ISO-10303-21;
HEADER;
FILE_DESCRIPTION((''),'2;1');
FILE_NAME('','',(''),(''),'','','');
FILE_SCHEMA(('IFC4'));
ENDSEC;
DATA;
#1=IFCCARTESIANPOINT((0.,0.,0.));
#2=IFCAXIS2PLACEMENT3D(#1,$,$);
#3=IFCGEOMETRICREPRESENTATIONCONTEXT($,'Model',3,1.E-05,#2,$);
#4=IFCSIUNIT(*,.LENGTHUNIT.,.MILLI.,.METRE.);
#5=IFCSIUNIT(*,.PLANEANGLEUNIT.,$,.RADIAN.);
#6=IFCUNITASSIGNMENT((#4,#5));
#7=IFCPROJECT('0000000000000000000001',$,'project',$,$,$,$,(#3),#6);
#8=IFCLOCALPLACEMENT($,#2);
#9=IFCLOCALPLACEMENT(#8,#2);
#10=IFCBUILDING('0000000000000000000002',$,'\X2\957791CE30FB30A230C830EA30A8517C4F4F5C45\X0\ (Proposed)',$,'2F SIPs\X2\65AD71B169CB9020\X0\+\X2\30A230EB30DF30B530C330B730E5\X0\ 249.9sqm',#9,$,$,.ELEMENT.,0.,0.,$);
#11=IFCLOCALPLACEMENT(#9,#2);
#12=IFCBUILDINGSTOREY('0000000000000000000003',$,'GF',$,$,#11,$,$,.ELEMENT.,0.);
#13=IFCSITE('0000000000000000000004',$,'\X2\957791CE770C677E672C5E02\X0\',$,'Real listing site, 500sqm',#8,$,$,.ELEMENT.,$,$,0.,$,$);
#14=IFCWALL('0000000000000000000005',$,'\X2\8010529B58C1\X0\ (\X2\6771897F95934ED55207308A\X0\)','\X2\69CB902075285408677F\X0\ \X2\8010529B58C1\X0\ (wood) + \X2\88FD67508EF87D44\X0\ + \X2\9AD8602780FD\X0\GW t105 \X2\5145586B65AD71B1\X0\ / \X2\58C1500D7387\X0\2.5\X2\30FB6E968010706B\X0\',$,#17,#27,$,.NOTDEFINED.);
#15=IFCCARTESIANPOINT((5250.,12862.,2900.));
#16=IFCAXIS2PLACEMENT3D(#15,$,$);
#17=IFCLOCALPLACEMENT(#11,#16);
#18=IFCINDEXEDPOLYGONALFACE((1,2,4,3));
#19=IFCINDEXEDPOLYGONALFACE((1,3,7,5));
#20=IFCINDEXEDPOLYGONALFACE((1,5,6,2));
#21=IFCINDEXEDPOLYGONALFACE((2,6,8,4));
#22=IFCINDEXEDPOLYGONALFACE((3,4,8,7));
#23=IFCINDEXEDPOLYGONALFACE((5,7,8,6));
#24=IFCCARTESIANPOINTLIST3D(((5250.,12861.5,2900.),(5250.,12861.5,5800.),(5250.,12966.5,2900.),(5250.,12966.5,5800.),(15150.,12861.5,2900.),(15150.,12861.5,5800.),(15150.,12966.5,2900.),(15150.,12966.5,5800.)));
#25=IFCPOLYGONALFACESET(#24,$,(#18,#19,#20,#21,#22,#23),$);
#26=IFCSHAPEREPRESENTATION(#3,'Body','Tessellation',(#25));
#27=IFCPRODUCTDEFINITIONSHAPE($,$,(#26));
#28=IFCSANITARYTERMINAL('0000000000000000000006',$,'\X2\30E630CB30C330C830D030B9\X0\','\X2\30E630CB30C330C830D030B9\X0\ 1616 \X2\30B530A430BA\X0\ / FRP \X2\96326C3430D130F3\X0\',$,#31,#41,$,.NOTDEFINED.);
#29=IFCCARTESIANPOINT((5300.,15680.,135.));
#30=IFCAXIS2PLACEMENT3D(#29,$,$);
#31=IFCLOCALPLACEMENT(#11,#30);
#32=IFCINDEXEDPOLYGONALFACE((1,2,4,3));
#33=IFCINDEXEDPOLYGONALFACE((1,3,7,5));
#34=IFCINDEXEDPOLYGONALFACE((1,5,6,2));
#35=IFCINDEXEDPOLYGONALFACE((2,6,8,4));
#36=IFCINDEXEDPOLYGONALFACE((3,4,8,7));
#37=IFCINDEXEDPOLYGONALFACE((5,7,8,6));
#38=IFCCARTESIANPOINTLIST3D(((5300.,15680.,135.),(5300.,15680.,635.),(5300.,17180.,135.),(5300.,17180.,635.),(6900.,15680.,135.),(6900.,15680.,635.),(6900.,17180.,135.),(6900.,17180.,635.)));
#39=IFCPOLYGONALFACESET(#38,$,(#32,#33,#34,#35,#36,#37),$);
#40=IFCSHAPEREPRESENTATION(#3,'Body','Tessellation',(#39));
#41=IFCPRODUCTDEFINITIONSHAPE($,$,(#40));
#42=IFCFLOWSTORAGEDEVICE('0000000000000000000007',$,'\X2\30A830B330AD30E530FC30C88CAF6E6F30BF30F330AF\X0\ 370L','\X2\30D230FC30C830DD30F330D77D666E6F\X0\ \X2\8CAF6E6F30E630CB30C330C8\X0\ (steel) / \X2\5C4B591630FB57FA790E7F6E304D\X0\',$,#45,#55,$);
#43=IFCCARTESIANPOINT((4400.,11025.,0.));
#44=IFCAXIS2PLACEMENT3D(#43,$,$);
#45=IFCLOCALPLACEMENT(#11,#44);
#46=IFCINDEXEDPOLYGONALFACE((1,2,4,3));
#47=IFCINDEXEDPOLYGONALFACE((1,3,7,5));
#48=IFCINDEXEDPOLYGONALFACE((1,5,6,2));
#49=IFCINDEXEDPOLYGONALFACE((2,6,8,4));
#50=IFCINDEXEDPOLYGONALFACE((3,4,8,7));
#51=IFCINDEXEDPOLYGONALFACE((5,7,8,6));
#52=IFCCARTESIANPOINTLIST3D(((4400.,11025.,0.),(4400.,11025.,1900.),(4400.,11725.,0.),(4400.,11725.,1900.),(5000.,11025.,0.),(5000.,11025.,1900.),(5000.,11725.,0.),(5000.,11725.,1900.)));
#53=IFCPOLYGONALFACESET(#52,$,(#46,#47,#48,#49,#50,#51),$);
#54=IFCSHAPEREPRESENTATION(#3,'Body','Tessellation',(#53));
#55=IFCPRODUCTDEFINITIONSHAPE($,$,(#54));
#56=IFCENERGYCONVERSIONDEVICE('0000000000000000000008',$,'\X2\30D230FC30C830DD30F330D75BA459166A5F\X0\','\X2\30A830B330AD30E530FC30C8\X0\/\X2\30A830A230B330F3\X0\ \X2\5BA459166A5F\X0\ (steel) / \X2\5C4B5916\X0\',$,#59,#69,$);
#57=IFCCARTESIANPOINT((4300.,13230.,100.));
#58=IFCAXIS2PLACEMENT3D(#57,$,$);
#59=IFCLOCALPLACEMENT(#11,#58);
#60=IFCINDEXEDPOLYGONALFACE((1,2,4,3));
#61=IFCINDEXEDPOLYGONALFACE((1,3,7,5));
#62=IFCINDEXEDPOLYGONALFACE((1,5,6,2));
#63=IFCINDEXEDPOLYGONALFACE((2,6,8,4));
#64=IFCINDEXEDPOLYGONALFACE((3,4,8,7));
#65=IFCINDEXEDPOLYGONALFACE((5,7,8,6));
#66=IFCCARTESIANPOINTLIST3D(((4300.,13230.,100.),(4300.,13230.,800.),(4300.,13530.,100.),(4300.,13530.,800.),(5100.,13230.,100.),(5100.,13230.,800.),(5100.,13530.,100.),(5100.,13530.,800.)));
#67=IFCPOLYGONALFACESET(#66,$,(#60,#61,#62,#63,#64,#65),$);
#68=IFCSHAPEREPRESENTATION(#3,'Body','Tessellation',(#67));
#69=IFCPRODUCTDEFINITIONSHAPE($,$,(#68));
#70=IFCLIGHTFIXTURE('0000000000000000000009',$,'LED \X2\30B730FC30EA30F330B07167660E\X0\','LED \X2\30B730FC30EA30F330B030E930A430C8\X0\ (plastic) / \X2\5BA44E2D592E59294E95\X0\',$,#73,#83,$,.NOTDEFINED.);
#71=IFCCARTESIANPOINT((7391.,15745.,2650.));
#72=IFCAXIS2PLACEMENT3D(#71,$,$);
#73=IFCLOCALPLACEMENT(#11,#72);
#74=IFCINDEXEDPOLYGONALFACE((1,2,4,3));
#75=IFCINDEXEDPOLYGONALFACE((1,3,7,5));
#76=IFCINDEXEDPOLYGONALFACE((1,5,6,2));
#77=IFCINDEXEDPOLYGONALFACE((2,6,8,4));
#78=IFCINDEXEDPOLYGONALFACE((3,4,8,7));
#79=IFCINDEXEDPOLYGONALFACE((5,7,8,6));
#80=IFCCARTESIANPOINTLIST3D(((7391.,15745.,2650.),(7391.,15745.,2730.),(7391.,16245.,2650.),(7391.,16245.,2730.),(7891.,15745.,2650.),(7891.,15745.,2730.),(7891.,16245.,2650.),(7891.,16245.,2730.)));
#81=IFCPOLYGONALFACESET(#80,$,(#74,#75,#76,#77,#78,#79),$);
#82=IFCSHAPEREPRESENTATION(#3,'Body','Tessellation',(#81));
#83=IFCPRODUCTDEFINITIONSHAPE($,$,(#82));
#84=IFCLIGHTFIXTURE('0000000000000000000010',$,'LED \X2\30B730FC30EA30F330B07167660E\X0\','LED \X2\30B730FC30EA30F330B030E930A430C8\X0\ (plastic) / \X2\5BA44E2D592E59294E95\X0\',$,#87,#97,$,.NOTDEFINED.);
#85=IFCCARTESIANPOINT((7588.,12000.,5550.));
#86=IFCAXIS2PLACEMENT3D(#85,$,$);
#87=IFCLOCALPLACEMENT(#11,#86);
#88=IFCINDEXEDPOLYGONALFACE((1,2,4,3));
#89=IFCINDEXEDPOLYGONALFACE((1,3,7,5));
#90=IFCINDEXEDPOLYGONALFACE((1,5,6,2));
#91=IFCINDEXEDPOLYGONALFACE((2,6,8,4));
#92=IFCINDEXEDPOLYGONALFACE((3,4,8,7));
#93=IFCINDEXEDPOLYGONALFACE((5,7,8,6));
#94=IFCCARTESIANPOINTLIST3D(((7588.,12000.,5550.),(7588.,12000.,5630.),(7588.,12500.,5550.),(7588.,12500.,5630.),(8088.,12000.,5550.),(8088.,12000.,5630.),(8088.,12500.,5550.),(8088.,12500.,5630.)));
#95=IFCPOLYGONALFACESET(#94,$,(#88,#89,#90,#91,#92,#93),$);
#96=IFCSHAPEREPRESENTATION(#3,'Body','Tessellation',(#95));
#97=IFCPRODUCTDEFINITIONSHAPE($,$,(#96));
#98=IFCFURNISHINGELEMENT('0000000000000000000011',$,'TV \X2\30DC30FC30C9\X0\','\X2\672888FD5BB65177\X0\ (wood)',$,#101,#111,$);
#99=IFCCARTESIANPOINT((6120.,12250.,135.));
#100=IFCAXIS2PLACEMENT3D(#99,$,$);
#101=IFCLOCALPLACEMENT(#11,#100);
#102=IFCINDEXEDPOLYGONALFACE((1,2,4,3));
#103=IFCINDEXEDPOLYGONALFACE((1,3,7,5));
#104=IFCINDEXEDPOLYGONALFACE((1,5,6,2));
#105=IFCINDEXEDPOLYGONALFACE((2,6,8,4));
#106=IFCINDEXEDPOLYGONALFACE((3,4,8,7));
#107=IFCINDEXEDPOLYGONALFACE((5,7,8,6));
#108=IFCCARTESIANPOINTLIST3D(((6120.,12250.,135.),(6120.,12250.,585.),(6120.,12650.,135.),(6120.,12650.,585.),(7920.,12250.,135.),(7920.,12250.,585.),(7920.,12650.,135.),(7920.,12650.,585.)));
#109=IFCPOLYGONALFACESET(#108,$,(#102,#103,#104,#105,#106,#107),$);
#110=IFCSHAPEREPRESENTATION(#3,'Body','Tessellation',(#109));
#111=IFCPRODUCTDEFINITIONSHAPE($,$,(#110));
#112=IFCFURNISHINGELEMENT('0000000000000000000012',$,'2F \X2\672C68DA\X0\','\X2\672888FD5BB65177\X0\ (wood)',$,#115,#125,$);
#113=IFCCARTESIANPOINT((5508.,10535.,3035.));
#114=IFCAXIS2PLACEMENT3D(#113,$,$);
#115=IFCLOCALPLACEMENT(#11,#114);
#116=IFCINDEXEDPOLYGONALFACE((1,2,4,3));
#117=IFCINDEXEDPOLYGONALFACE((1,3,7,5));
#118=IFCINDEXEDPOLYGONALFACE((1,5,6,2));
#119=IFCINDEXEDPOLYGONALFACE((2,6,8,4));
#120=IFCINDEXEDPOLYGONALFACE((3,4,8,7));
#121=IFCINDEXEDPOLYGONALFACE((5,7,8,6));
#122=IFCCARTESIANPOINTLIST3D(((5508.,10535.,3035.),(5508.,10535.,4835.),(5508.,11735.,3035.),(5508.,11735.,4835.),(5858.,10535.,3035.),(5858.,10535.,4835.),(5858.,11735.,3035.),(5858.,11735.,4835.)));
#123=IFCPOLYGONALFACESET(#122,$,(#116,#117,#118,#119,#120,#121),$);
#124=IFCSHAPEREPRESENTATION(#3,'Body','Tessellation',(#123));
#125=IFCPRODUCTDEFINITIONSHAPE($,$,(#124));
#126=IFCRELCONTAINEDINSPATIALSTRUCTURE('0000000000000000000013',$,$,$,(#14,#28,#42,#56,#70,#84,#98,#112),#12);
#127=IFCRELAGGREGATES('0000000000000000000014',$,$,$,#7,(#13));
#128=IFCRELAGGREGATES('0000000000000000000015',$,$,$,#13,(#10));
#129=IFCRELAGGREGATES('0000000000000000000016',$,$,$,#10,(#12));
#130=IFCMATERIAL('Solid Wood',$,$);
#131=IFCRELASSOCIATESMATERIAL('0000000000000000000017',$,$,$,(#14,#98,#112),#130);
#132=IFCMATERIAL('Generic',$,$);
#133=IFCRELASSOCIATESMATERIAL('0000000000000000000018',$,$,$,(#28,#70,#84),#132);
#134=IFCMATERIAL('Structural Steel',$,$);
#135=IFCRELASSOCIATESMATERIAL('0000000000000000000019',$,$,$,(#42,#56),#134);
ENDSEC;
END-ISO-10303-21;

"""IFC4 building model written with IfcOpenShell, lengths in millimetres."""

from ifc_helpers import new_model, si_unit, frame, frame_2d, origin, place, context, project, spatial, rectangle, extrude, material, element, save


model = new_model("IFC4")

# Units and contexts
model_context = context("Model", 3, precision=1e-05, world=origin())
ifc_project = project(units=[si_unit("LENGTHUNIT", "METRE", prefix="MILLI"), si_unit("PLANEANGLEUNIT", "RADIAN")], contexts=[model_context])

# Site, building, storey
site_placement = place(None, origin())
site = spatial("IfcSite", under=ifc_project, at=site_placement, Name="長野県松本市", ObjectType="Real listing site, 500sqm", CompositionType="ELEMENT", RefElevation=0.0)
building_placement = place(site_placement, origin())
building = spatial("IfcBuilding", under=site, at=building_placement, Name="長野・アトリエ兼住居 (Proposed)", ObjectType="2F SIPs断熱構造+アルミサッシュ 249.9sqm", CompositionType="ELEMENT", ElevationOfRefHeight=0.0, ElevationOfTerrain=0.0)
storey_placement = place(building_placement, origin())
storey = spatial("IfcBuildingStorey", under=building, at=storey_placement, Name="GF", CompositionType="ELEMENT", Elevation=0.0)

# Shared definitions
ifc_material_1 = material(Name="Solid Wood")

# Wall
wall_1_placement = place(storey_placement, frame((5250.0, 12862.0, 2900.0)))
element("IfcWall", 1, at=wall_1_placement, inside=storey, material=ifc_material_1, Name="耐力壁 (東西間仕切り)", Description="構造用合板 耐力壁 (wood) + 製材軸組 + 高性能GW t105 充填断熱 / 壁倍率2.5・準耐火", PredefinedType="NOTDEFINED", context=model_context, shape_type="SweptSolid", body=[
    extrude(rectangle(XDim=9900.0, YDim=105.0, at=frame_2d((4950.0, 52.0))), frame((5250.0, 12862.0, 2900.0)), (0.0, 0.0, 1.0), 2900.0),
])

# Sanitary terminal
ifc_material_2 = material(Name="Generic")
sanitary_terminal_placement = place(storey_placement, frame((5300.0, 15680.0, 135.0)))
element("IfcSanitaryTerminal", 2, at=sanitary_terminal_placement, inside=storey, material=ifc_material_2, Name="ユニットバス", Description="ユニットバス 1616 サイズ / FRP 防水パン", PredefinedType="NOTDEFINED", context=model_context, shape_type="SweptSolid", body=[
    extrude(rectangle(XDim=1600.0, YDim=1500.0, at=frame_2d((800.0, 750.0))), frame((5300.0, 15680.0, 135.0)), (0.0, 0.0, 1.0), 500.0),
])

# Flow storage device
ifc_material_3 = material(Name="Structural Steel")
flow_storage_device_placement = place(storey_placement, frame((4400.0, 11025.0, 0.0)))
element("IfcFlowStorageDevice", 3, at=flow_storage_device_placement, inside=storey, material=ifc_material_3, Name="エコキュート貯湯タンク 370L", Description="ヒートポンプ給湯 貯湯ユニット (steel) / 屋外・基礎置き", context=model_context, shape_type="SweptSolid", body=[
    extrude(rectangle(XDim=600.0, YDim=700.0, at=frame_2d((300.0, 350.0))), frame((4400.0, 11025.0, 0.0)), (0.0, 0.0, 1.0), 1900.0),
])

# Energy conversion device
energy_conversion_device_placement = place(storey_placement, frame((4300.0, 13230.0, 100.0)))
element("IfcEnergyConversionDevice", 4, at=energy_conversion_device_placement, inside=storey, material=ifc_material_3, Name="ヒートポンプ室外機", Description="エコキュート/エアコン 室外機 (steel) / 屋外", context=model_context, shape_type="SweptSolid", body=[
    extrude(rectangle(XDim=800.0, YDim=300.0, at=frame_2d((400.0, 150.0))), frame((4300.0, 13230.0, 100.0)), (0.0, 0.0, 1.0), 700.0),
])

# Light fixtures
light_fixture_1_placement = place(storey_placement, frame((7391.0, 15745.0, 2650.0)))
element("IfcLightFixture", 5, at=light_fixture_1_placement, inside=storey, material=ifc_material_2, Name="LED シーリング照明", Description="LED シーリングライト (plastic) / 室中央天井", PredefinedType="NOTDEFINED", context=model_context, shape_type="SweptSolid", body=[
    extrude(rectangle(XDim=500.0, YDim=500.0, at=frame_2d((250.0, 250.0))), frame((7391.0, 15745.0, 2650.0)), (0.0, 0.0, 1.0), 80.0),
])
light_fixture_2_placement = place(storey_placement, frame((7588.0, 12000.0, 5550.0)))
element("IfcLightFixture", 6, at=light_fixture_2_placement, inside=storey, material=ifc_material_2, Name="LED シーリング照明", Description="LED シーリングライト (plastic) / 室中央天井", PredefinedType="NOTDEFINED", context=model_context, shape_type="SweptSolid", body=[
    extrude(rectangle(XDim=500.0, YDim=500.0, at=frame_2d((250.0, 250.0))), frame((7588.0, 12000.0, 5550.0)), (0.0, 0.0, 1.0), 80.0),
])

# Furnishing elements
furnishing_1_placement = place(storey_placement, frame((6120.0, 12250.0, 135.0)))
element("IfcFurnishingElement", 7, at=furnishing_1_placement, inside=storey, material=ifc_material_1, Name="TV ボード", Description="木製家具 (wood)", context=model_context, shape_type="SweptSolid", body=[
    extrude(rectangle(XDim=1800.0, YDim=400.0, at=frame_2d((900.0, 200.0))), frame((6120.0, 12250.0, 135.0)), (0.0, 0.0, 1.0), 450.0),
])
furnishing_2_placement = place(storey_placement, frame((5508.0, 10535.0, 3035.0)))
element("IfcFurnishingElement", 8, at=furnishing_2_placement, inside=storey, material=ifc_material_1, Name="2F 本棚", Description="木製家具 (wood)", context=model_context, shape_type="SweptSolid", body=[
    extrude(rectangle(XDim=350.0, YDim=1200.0, at=frame_2d((175.0, 600.0))), frame((5508.0, 10535.0, 3035.0)), (0.0, 0.0, 1.0), 1800.0),
])

save(model, "model.ifc")
